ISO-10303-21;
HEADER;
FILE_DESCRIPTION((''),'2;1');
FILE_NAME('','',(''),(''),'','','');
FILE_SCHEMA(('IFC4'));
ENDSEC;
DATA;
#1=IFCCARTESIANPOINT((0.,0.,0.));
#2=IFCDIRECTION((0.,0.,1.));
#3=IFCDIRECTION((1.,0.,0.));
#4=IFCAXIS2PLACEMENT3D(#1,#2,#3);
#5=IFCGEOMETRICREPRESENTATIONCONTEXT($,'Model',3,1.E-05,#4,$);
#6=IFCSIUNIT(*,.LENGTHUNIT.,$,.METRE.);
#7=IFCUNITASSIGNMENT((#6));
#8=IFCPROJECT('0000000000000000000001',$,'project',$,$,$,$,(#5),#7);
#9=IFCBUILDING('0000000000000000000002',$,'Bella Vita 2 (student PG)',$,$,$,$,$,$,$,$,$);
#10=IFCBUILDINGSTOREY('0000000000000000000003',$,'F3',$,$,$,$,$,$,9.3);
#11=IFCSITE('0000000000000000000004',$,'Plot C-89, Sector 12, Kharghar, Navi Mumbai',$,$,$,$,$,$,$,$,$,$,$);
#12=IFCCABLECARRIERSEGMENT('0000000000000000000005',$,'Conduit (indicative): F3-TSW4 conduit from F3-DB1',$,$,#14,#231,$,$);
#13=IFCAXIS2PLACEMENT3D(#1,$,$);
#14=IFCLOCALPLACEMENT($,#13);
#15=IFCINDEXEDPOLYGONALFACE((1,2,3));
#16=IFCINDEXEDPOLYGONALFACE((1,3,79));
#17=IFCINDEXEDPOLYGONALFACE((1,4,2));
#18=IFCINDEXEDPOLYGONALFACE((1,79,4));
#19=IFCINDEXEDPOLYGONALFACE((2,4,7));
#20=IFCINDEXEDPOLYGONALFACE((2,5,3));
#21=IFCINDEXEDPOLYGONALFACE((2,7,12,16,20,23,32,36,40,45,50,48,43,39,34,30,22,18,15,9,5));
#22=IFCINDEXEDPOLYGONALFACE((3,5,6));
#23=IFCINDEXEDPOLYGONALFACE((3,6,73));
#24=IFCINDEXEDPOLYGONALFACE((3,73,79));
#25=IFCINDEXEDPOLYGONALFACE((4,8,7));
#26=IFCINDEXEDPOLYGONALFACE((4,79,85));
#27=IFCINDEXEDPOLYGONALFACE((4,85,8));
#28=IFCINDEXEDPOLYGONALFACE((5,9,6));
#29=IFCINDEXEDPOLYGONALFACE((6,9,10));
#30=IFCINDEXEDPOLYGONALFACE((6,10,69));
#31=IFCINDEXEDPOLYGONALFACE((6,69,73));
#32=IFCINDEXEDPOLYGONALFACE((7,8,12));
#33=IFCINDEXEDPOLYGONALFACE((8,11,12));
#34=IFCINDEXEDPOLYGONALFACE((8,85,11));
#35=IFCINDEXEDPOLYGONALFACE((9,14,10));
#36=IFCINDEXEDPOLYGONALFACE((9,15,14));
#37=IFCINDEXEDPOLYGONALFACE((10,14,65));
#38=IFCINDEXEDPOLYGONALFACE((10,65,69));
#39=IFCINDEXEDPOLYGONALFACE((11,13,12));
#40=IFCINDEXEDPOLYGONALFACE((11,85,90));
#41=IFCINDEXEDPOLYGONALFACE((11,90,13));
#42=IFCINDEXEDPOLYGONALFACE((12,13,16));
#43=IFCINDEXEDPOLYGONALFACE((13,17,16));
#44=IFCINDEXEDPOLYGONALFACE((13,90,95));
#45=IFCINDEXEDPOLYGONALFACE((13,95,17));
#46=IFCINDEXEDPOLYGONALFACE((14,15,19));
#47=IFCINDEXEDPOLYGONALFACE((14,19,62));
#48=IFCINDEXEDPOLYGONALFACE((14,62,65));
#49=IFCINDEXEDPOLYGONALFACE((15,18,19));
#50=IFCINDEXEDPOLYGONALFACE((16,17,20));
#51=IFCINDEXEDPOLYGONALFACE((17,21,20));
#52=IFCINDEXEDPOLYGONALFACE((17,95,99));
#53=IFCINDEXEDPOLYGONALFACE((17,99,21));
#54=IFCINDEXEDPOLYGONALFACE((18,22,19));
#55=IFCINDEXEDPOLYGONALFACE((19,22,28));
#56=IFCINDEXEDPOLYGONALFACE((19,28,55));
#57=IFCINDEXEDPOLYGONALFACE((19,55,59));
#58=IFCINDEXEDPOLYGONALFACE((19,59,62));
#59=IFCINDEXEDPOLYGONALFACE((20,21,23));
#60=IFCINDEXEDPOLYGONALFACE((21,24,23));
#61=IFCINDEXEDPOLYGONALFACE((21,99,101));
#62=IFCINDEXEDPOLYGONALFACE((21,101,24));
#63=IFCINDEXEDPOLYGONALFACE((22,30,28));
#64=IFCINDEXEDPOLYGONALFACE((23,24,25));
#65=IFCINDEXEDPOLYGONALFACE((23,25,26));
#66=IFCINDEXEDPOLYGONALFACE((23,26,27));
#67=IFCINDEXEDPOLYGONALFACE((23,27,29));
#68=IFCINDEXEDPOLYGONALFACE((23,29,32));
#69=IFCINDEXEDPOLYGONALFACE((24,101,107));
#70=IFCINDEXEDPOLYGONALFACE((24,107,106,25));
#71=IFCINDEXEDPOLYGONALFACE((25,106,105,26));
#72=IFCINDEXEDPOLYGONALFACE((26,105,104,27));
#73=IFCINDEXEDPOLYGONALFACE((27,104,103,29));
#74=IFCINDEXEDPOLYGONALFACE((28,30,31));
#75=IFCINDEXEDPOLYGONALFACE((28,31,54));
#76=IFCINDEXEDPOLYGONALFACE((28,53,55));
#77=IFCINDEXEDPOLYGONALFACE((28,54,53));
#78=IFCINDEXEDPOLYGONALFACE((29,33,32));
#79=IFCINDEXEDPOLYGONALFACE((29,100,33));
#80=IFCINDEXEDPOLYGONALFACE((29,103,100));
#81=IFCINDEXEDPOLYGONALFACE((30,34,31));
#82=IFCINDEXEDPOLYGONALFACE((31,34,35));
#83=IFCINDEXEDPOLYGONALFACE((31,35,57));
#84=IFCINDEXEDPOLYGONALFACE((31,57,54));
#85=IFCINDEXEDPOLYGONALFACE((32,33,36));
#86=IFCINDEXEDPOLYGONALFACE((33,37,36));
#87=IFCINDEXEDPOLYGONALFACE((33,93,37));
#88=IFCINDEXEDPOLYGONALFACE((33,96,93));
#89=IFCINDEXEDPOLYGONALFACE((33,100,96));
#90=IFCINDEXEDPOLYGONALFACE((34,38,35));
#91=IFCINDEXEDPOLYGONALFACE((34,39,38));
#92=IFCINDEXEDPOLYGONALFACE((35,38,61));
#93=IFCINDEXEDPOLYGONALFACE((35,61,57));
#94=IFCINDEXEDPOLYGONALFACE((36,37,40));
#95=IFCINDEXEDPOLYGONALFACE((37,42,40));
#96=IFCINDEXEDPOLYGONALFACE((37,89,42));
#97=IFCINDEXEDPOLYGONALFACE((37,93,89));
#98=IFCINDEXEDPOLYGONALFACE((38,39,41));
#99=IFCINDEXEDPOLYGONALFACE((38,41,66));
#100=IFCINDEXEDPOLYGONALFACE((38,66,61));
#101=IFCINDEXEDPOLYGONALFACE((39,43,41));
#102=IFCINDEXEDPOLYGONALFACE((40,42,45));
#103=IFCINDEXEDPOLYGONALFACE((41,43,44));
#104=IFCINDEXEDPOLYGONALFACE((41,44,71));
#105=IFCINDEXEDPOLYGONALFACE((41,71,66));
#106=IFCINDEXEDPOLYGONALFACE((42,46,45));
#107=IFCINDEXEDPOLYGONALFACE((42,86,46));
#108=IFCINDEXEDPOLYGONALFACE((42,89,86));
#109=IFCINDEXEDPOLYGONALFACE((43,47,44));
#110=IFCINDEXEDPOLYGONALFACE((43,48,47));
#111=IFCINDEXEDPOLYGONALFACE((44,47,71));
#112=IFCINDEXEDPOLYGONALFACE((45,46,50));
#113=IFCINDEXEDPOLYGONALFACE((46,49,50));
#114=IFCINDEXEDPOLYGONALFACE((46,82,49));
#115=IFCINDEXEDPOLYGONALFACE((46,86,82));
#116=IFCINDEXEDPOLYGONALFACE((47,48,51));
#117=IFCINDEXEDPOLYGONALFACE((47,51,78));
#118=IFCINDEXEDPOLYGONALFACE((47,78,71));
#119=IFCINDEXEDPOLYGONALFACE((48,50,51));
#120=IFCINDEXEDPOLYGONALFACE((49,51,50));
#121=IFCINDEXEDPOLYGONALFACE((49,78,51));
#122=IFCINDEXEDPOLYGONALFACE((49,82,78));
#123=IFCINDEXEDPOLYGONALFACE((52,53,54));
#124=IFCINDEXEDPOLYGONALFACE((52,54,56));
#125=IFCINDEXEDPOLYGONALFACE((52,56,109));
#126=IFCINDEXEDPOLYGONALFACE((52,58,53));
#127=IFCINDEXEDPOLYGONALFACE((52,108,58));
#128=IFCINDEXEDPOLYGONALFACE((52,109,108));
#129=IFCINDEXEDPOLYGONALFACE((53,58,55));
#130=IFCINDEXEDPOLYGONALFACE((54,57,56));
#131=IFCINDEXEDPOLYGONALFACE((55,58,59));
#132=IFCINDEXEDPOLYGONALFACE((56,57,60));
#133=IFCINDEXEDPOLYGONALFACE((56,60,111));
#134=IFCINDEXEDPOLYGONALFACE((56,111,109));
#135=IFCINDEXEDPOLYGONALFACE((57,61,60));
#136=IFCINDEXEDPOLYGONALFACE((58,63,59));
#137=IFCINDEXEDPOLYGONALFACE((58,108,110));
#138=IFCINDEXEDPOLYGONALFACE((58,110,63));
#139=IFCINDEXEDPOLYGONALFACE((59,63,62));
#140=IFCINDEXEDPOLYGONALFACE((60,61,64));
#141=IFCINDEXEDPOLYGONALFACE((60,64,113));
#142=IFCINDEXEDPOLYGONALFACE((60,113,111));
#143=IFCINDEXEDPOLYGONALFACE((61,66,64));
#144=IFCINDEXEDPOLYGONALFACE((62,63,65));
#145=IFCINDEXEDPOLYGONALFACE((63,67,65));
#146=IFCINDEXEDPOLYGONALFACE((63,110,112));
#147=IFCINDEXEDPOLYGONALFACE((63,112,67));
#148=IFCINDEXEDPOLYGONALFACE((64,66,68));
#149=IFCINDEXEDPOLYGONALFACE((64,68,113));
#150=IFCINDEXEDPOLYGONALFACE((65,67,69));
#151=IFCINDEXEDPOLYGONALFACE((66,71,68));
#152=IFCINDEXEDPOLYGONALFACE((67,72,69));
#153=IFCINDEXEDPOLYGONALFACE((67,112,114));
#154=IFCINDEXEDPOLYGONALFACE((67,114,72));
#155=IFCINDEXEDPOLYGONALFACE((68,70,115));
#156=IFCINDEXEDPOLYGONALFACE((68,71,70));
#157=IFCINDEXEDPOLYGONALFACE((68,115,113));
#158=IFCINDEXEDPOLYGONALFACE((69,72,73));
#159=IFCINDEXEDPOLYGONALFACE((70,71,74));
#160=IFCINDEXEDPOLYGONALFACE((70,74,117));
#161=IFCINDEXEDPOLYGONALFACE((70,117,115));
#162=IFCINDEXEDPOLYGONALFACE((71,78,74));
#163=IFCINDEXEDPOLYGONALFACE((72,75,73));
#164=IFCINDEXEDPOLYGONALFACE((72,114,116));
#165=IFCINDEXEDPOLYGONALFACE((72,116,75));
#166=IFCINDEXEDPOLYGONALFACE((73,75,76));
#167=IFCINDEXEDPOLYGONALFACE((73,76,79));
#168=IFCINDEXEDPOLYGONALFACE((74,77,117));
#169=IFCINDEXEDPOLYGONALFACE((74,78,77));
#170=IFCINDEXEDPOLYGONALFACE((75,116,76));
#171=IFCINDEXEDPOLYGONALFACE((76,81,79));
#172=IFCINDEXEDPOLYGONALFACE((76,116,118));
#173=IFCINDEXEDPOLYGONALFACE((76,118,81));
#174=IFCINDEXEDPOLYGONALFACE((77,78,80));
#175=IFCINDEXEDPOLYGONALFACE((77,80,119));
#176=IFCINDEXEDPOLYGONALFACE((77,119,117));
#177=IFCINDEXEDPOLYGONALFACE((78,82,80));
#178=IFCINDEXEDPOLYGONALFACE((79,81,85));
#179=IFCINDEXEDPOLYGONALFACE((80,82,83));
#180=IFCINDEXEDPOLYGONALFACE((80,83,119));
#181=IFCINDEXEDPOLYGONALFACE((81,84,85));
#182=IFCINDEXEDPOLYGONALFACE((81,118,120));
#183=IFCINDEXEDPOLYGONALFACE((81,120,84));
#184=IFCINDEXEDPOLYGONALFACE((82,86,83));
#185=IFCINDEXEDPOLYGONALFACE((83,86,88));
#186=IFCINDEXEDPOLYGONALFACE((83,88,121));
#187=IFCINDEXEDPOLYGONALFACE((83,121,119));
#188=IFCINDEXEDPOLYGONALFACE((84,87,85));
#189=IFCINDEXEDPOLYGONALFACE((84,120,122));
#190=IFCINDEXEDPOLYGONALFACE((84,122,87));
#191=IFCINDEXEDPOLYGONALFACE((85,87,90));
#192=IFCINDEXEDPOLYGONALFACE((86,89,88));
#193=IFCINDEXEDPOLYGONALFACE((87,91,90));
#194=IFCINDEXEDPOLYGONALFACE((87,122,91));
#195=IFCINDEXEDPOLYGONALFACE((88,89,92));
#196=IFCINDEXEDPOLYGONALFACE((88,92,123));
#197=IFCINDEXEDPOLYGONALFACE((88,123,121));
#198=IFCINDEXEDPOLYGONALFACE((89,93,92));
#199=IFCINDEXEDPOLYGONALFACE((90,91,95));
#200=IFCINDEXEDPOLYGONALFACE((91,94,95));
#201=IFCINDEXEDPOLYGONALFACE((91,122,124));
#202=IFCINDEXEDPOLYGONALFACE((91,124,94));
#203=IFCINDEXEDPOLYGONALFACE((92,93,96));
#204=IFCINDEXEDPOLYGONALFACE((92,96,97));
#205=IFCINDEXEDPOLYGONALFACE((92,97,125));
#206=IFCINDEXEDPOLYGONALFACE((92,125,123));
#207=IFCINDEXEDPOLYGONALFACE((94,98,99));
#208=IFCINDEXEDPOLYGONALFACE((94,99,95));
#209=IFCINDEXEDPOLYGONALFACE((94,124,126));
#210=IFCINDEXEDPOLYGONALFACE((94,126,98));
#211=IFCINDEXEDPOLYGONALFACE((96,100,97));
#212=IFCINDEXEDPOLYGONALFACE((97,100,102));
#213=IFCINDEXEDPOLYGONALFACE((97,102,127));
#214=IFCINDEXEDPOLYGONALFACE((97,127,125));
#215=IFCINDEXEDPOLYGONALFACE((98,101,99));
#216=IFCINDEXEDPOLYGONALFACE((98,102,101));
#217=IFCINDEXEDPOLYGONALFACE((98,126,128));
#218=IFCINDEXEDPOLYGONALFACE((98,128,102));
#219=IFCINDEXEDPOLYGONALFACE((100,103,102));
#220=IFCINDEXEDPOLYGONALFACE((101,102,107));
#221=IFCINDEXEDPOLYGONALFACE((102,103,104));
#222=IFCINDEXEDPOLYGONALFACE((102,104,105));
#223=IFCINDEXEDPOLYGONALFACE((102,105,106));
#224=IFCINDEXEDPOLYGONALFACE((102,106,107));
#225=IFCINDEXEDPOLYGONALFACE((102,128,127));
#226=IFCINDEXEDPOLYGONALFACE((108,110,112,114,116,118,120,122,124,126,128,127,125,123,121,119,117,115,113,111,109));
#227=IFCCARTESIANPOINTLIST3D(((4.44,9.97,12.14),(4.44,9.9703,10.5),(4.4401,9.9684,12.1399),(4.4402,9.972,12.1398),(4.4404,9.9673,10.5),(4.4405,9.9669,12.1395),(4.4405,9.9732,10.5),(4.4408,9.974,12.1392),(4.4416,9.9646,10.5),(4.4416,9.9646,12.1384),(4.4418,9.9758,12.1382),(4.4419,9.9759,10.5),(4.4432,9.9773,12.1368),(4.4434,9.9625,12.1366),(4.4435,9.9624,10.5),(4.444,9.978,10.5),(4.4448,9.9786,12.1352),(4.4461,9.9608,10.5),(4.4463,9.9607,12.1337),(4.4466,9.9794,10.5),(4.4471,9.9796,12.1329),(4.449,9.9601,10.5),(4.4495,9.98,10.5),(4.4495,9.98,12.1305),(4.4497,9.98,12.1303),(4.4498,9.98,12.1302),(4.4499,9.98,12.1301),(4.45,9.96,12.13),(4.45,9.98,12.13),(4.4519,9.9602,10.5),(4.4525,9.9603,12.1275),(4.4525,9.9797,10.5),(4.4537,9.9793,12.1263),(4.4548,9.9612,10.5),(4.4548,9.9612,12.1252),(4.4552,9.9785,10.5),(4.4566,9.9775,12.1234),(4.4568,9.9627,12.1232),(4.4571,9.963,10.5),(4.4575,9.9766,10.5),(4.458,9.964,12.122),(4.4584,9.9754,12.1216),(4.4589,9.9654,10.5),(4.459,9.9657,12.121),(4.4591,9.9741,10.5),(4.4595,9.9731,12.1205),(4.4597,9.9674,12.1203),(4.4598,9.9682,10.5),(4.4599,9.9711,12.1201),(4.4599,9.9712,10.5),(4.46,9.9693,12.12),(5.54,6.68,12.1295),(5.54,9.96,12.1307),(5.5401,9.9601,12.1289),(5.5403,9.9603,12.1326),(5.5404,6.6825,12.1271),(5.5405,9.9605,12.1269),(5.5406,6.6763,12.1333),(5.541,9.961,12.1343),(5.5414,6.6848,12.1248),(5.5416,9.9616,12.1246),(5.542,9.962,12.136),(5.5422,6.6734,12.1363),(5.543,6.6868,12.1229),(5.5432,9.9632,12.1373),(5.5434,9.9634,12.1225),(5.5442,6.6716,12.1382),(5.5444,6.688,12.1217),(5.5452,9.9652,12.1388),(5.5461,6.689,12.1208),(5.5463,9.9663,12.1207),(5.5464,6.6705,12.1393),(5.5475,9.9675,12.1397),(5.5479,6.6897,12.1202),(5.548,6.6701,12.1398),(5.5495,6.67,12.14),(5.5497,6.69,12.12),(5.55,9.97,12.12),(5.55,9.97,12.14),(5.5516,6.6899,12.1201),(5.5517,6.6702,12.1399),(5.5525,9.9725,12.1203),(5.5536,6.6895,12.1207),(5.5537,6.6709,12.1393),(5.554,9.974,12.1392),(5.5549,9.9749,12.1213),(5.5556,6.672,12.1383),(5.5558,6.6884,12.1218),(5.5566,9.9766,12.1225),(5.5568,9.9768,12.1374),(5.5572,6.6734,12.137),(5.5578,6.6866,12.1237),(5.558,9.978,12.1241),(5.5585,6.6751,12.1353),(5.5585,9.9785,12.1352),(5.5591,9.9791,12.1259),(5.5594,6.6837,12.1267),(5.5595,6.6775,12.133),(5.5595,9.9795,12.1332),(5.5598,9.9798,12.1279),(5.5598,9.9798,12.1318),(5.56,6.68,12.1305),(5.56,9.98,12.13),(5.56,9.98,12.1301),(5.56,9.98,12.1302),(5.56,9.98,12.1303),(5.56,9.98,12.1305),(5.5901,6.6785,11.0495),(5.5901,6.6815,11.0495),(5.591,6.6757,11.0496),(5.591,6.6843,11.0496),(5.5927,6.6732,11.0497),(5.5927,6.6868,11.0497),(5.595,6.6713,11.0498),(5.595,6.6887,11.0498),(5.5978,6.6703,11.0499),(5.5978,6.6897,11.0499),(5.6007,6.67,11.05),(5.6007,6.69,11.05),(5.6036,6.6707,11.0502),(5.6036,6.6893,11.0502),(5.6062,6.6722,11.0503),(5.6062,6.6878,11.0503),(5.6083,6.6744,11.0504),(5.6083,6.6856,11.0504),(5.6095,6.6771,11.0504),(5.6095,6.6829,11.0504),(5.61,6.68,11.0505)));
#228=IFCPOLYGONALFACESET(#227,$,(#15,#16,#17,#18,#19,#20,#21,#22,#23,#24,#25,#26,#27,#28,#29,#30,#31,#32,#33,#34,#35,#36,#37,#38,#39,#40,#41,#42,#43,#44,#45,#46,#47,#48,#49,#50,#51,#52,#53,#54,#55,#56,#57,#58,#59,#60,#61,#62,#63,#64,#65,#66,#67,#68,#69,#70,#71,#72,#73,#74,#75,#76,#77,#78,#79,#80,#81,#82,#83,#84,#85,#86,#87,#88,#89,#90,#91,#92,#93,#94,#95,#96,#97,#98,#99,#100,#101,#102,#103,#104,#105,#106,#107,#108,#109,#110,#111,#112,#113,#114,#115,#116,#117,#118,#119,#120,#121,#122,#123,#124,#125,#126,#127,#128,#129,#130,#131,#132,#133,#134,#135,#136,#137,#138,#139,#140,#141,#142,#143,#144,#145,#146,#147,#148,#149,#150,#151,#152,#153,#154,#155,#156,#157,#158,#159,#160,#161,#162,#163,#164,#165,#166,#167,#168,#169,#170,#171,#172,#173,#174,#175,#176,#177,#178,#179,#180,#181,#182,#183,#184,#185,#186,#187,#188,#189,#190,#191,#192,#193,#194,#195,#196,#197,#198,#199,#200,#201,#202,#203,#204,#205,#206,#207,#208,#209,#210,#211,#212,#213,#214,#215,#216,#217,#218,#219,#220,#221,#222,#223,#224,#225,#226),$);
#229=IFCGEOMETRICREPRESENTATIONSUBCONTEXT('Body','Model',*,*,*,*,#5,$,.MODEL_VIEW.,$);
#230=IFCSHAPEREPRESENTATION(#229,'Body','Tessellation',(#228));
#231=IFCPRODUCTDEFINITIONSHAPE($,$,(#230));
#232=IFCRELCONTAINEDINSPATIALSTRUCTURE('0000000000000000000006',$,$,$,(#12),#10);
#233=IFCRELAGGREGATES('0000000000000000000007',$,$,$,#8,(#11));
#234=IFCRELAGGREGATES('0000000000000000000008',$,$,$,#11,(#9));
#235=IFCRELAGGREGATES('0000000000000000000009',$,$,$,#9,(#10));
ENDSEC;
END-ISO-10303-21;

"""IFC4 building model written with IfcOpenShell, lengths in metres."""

from ifc_helpers import new_model, entity, si_unit, origin, origin_with_axes, place, context, subcontext, project, spatial, element, save


model = new_model("IFC4")

# Units and contexts
model_context = context("Model", 3, precision=1e-05, world=origin_with_axes())
body_context = subcontext(model_context, "Body", "Model", "MODEL_VIEW")
ifc_project = project(units=[si_unit("LENGTHUNIT", "METRE")], contexts=[model_context])

# Site, building, storey
site = spatial("IfcSite", under=ifc_project, Name="Plot C-89, Sector 12, Kharghar, Navi Mumbai")
building = spatial("IfcBuilding", under=site, Name="Bella Vita 2 (student PG)")
storey = spatial("IfcBuildingStorey", under=building, Name="F3", Elevation=9.3)

# Cable carrier segment
cable_carrier_segment_1_placement = place(None, origin())
element("IfcCableCarrierSegment", 1, at=cable_carrier_segment_1_placement, inside=storey, Name="Conduit (indicative): F3-TSW4 conduit from F3-DB1", context=body_context, shape_type="AdvancedSweptSolid", body=[
    entity("IfcSweptDiskSolid", entity("IfcPolyline", [entity("IfcCartesianPoint", [5.6, 6.68, 11.05]), entity("IfcCartesianPoint", [5.55, 6.68, 12.13]), entity("IfcCartesianPoint", [5.55, 9.97, 12.13]), entity("IfcCartesianPoint", [4.45, 9.97, 12.13]), entity("IfcCartesianPoint", [4.45, 9.97, 10.5])]), 0.01),
])

save(model, "model.ifc")
